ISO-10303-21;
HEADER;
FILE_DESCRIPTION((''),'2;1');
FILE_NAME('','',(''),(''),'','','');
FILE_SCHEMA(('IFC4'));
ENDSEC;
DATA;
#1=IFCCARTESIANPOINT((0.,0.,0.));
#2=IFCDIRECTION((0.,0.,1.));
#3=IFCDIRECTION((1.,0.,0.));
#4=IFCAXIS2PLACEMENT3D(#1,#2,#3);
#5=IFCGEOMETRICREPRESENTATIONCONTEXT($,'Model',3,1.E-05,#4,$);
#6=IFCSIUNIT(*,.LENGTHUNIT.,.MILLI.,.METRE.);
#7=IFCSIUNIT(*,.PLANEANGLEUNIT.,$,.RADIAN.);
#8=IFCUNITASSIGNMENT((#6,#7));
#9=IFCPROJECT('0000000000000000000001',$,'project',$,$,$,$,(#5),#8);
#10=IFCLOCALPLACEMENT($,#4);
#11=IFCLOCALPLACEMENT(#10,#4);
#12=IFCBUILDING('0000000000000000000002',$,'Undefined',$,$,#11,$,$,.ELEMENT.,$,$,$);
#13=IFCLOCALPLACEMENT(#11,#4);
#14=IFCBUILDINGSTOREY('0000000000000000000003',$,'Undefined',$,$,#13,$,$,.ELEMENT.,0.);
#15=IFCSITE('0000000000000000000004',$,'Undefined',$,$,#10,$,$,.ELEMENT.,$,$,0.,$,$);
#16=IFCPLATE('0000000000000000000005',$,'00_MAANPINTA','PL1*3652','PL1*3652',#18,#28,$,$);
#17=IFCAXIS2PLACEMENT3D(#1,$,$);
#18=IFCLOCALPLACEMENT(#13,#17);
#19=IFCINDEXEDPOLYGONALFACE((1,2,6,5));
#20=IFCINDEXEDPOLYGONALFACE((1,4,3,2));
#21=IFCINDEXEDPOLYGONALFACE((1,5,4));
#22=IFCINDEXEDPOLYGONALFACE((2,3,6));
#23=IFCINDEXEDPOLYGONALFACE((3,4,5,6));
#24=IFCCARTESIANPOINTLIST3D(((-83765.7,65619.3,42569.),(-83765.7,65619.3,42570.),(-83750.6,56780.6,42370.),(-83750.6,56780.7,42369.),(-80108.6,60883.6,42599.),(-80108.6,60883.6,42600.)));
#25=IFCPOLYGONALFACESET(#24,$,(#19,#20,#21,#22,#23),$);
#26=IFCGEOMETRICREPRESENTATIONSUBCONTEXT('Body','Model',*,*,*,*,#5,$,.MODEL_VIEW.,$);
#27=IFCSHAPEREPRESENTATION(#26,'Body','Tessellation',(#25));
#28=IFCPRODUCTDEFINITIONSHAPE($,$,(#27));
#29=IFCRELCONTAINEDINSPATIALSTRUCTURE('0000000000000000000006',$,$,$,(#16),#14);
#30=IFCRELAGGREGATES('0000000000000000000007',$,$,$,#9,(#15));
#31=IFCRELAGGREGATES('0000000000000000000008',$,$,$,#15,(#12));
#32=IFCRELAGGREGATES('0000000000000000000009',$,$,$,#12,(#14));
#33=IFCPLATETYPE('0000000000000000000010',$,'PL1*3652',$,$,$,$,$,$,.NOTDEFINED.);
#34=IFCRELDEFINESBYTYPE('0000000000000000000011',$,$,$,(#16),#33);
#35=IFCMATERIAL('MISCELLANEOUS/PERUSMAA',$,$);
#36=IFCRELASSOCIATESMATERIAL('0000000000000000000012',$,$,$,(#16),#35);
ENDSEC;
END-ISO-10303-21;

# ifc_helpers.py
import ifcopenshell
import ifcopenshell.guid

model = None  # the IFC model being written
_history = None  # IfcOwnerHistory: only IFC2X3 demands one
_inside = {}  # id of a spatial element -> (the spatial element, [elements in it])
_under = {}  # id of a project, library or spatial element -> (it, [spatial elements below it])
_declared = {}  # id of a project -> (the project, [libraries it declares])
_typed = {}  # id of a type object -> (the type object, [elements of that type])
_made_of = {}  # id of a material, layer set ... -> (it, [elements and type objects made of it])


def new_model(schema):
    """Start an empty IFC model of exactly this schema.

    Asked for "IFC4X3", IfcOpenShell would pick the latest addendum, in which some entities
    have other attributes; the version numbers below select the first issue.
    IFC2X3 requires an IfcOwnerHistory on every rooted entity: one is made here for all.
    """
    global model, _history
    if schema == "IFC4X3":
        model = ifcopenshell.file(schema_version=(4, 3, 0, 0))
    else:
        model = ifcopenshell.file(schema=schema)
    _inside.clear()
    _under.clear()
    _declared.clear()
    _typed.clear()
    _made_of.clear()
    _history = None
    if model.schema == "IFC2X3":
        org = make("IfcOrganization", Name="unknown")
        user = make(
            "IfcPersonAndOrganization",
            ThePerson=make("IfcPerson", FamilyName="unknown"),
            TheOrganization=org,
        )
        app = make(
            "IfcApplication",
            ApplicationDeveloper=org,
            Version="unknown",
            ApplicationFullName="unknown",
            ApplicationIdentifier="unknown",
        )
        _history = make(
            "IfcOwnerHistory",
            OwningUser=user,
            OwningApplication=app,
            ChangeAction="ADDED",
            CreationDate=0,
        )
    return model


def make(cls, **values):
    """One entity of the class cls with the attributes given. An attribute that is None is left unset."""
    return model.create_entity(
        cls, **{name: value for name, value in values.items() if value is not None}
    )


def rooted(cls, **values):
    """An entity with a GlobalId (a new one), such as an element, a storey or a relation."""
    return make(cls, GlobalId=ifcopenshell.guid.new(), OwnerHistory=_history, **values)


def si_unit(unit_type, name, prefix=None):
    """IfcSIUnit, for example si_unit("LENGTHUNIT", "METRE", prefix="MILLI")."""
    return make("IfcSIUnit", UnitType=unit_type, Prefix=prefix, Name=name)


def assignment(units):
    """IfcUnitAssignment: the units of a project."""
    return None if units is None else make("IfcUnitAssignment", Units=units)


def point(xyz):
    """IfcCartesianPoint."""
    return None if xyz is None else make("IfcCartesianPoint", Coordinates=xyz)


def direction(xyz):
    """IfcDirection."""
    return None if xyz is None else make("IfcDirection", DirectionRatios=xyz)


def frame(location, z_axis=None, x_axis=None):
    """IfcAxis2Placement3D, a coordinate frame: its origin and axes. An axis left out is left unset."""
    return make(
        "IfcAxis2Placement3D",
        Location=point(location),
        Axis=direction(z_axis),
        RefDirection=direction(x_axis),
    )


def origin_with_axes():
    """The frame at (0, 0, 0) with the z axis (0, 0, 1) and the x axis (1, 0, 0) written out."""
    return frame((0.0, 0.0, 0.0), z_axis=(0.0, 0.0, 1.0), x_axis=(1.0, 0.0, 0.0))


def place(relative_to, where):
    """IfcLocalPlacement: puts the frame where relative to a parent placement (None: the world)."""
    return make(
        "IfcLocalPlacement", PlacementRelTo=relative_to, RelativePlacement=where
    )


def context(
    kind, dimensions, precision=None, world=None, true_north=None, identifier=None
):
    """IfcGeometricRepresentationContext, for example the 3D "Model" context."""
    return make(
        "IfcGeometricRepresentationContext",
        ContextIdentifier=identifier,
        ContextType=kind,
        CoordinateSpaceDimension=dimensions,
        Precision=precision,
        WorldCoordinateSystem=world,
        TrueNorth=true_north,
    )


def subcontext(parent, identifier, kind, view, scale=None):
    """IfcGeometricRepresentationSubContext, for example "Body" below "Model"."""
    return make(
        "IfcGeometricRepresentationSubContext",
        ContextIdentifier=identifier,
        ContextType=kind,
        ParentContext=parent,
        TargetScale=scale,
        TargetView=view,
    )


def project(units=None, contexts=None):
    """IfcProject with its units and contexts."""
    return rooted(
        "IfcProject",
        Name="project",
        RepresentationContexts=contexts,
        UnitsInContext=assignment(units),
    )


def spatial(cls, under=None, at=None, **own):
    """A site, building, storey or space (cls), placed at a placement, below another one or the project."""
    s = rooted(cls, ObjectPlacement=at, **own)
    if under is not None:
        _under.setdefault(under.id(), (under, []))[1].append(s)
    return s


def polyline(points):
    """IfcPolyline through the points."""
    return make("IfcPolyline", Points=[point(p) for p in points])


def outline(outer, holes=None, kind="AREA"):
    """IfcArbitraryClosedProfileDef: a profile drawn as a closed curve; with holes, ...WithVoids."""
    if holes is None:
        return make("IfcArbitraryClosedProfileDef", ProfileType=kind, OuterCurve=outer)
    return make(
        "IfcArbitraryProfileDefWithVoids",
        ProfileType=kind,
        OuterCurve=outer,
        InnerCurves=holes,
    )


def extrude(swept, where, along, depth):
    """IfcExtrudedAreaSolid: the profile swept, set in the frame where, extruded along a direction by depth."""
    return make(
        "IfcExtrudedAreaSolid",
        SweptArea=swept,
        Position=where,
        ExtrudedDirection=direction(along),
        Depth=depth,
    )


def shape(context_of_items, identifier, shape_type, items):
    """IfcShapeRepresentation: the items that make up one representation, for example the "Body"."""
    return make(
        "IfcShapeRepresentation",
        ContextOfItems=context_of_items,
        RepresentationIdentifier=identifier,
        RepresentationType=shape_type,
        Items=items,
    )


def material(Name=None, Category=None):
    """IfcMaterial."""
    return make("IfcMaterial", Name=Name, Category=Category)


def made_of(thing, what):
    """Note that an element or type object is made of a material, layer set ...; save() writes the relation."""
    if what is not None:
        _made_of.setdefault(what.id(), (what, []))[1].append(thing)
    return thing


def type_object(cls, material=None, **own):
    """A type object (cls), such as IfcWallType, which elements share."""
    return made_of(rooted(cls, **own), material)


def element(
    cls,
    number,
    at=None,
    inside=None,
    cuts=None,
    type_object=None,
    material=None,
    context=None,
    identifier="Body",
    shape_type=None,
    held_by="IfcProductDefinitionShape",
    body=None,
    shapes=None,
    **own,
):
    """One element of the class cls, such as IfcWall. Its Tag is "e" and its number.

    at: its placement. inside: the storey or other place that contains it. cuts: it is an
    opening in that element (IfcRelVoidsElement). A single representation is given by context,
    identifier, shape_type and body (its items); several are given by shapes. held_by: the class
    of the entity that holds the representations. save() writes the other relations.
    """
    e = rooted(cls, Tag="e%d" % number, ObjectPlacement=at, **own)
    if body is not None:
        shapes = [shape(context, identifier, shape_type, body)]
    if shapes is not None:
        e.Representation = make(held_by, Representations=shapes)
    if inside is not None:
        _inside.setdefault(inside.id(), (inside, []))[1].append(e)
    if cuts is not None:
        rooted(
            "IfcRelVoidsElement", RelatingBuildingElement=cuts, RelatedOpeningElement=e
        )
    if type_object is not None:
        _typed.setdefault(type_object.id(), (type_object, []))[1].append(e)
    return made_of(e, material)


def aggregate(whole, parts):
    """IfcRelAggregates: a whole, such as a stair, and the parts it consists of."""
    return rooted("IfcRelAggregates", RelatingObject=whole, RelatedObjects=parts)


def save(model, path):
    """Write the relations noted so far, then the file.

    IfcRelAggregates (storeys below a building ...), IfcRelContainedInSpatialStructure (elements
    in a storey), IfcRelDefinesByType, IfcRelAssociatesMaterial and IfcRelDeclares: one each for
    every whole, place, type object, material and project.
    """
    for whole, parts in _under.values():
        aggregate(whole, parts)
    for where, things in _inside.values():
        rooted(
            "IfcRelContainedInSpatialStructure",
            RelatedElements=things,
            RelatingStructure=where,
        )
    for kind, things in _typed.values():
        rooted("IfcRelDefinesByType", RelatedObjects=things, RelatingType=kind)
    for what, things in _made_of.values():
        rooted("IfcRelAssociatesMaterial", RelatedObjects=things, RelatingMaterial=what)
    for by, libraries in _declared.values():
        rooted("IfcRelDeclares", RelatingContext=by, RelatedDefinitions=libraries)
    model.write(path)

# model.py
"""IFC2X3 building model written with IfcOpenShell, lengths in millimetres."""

from ifc_helpers import new_model, si_unit, frame, origin_with_axes, place, context, subcontext, project, spatial, polyline, outline, extrude, material, type_object, element, save


model = new_model("IFC2X3")

# Units and contexts
model_context = context("Model", 3, precision=1e-05, world=origin_with_axes())
body_context = subcontext(model_context, "Body", "Model", "MODEL_VIEW")
ifc_project = project(units=[si_unit("LENGTHUNIT", "METRE", prefix="MILLI"), si_unit("PLANEANGLEUNIT", "RADIAN")], contexts=[model_context])

# Site, building, storey
site_placement = place(None, origin_with_axes())
site = spatial("IfcSite", under=ifc_project, at=site_placement, Name="Undefined", CompositionType="ELEMENT", RefElevation=0.0)
building_placement = place(site_placement, origin_with_axes())
building = spatial("IfcBuilding", under=site, at=building_placement, Name="Undefined", CompositionType="ELEMENT")
storey_placement = place(building_placement, origin_with_axes())
storey = spatial("IfcBuildingStorey", under=building, at=storey_placement, Name="Undefined", CompositionType="ELEMENT", Elevation=0.0)

# Plate
ifc_material = material(Name="MISCELLANEOUS/PERUSMAA")
plate_type_1 = type_object("IfcPlateType", Name="PL1*3652", PredefinedType="NOTDEFINED")
plate_1_placement = place(storey_placement, frame((-83765.7, 65619.3, 42569.5), z_axis=(0.037552, 0.02267, -0.999038), x_axis=(0.611205, -0.791457, 0.005014)))
element("IfcPlate", 1, at=plate_1_placement, inside=storey, type_object=plate_type_1, material=ifc_material, Name="00_MAANPINTA", Description="PL1*3652", ObjectType="PL1*3652", context=body_context, shape_type="SweptSolid", body=[
    extrude(outline(polyline([(0.0, 0.0), (5983.5, 0.0), (7003.6, 5395.4), (0.0, 0.0)])), frame((0.0, 0.0, -0.5), z_axis=(0.0, 0.0, 1.0), x_axis=(1.0, 0.0, 0.0)), (0.0, 0.0, 1.0), 1.0),
])

save(model, "model.ifc")
